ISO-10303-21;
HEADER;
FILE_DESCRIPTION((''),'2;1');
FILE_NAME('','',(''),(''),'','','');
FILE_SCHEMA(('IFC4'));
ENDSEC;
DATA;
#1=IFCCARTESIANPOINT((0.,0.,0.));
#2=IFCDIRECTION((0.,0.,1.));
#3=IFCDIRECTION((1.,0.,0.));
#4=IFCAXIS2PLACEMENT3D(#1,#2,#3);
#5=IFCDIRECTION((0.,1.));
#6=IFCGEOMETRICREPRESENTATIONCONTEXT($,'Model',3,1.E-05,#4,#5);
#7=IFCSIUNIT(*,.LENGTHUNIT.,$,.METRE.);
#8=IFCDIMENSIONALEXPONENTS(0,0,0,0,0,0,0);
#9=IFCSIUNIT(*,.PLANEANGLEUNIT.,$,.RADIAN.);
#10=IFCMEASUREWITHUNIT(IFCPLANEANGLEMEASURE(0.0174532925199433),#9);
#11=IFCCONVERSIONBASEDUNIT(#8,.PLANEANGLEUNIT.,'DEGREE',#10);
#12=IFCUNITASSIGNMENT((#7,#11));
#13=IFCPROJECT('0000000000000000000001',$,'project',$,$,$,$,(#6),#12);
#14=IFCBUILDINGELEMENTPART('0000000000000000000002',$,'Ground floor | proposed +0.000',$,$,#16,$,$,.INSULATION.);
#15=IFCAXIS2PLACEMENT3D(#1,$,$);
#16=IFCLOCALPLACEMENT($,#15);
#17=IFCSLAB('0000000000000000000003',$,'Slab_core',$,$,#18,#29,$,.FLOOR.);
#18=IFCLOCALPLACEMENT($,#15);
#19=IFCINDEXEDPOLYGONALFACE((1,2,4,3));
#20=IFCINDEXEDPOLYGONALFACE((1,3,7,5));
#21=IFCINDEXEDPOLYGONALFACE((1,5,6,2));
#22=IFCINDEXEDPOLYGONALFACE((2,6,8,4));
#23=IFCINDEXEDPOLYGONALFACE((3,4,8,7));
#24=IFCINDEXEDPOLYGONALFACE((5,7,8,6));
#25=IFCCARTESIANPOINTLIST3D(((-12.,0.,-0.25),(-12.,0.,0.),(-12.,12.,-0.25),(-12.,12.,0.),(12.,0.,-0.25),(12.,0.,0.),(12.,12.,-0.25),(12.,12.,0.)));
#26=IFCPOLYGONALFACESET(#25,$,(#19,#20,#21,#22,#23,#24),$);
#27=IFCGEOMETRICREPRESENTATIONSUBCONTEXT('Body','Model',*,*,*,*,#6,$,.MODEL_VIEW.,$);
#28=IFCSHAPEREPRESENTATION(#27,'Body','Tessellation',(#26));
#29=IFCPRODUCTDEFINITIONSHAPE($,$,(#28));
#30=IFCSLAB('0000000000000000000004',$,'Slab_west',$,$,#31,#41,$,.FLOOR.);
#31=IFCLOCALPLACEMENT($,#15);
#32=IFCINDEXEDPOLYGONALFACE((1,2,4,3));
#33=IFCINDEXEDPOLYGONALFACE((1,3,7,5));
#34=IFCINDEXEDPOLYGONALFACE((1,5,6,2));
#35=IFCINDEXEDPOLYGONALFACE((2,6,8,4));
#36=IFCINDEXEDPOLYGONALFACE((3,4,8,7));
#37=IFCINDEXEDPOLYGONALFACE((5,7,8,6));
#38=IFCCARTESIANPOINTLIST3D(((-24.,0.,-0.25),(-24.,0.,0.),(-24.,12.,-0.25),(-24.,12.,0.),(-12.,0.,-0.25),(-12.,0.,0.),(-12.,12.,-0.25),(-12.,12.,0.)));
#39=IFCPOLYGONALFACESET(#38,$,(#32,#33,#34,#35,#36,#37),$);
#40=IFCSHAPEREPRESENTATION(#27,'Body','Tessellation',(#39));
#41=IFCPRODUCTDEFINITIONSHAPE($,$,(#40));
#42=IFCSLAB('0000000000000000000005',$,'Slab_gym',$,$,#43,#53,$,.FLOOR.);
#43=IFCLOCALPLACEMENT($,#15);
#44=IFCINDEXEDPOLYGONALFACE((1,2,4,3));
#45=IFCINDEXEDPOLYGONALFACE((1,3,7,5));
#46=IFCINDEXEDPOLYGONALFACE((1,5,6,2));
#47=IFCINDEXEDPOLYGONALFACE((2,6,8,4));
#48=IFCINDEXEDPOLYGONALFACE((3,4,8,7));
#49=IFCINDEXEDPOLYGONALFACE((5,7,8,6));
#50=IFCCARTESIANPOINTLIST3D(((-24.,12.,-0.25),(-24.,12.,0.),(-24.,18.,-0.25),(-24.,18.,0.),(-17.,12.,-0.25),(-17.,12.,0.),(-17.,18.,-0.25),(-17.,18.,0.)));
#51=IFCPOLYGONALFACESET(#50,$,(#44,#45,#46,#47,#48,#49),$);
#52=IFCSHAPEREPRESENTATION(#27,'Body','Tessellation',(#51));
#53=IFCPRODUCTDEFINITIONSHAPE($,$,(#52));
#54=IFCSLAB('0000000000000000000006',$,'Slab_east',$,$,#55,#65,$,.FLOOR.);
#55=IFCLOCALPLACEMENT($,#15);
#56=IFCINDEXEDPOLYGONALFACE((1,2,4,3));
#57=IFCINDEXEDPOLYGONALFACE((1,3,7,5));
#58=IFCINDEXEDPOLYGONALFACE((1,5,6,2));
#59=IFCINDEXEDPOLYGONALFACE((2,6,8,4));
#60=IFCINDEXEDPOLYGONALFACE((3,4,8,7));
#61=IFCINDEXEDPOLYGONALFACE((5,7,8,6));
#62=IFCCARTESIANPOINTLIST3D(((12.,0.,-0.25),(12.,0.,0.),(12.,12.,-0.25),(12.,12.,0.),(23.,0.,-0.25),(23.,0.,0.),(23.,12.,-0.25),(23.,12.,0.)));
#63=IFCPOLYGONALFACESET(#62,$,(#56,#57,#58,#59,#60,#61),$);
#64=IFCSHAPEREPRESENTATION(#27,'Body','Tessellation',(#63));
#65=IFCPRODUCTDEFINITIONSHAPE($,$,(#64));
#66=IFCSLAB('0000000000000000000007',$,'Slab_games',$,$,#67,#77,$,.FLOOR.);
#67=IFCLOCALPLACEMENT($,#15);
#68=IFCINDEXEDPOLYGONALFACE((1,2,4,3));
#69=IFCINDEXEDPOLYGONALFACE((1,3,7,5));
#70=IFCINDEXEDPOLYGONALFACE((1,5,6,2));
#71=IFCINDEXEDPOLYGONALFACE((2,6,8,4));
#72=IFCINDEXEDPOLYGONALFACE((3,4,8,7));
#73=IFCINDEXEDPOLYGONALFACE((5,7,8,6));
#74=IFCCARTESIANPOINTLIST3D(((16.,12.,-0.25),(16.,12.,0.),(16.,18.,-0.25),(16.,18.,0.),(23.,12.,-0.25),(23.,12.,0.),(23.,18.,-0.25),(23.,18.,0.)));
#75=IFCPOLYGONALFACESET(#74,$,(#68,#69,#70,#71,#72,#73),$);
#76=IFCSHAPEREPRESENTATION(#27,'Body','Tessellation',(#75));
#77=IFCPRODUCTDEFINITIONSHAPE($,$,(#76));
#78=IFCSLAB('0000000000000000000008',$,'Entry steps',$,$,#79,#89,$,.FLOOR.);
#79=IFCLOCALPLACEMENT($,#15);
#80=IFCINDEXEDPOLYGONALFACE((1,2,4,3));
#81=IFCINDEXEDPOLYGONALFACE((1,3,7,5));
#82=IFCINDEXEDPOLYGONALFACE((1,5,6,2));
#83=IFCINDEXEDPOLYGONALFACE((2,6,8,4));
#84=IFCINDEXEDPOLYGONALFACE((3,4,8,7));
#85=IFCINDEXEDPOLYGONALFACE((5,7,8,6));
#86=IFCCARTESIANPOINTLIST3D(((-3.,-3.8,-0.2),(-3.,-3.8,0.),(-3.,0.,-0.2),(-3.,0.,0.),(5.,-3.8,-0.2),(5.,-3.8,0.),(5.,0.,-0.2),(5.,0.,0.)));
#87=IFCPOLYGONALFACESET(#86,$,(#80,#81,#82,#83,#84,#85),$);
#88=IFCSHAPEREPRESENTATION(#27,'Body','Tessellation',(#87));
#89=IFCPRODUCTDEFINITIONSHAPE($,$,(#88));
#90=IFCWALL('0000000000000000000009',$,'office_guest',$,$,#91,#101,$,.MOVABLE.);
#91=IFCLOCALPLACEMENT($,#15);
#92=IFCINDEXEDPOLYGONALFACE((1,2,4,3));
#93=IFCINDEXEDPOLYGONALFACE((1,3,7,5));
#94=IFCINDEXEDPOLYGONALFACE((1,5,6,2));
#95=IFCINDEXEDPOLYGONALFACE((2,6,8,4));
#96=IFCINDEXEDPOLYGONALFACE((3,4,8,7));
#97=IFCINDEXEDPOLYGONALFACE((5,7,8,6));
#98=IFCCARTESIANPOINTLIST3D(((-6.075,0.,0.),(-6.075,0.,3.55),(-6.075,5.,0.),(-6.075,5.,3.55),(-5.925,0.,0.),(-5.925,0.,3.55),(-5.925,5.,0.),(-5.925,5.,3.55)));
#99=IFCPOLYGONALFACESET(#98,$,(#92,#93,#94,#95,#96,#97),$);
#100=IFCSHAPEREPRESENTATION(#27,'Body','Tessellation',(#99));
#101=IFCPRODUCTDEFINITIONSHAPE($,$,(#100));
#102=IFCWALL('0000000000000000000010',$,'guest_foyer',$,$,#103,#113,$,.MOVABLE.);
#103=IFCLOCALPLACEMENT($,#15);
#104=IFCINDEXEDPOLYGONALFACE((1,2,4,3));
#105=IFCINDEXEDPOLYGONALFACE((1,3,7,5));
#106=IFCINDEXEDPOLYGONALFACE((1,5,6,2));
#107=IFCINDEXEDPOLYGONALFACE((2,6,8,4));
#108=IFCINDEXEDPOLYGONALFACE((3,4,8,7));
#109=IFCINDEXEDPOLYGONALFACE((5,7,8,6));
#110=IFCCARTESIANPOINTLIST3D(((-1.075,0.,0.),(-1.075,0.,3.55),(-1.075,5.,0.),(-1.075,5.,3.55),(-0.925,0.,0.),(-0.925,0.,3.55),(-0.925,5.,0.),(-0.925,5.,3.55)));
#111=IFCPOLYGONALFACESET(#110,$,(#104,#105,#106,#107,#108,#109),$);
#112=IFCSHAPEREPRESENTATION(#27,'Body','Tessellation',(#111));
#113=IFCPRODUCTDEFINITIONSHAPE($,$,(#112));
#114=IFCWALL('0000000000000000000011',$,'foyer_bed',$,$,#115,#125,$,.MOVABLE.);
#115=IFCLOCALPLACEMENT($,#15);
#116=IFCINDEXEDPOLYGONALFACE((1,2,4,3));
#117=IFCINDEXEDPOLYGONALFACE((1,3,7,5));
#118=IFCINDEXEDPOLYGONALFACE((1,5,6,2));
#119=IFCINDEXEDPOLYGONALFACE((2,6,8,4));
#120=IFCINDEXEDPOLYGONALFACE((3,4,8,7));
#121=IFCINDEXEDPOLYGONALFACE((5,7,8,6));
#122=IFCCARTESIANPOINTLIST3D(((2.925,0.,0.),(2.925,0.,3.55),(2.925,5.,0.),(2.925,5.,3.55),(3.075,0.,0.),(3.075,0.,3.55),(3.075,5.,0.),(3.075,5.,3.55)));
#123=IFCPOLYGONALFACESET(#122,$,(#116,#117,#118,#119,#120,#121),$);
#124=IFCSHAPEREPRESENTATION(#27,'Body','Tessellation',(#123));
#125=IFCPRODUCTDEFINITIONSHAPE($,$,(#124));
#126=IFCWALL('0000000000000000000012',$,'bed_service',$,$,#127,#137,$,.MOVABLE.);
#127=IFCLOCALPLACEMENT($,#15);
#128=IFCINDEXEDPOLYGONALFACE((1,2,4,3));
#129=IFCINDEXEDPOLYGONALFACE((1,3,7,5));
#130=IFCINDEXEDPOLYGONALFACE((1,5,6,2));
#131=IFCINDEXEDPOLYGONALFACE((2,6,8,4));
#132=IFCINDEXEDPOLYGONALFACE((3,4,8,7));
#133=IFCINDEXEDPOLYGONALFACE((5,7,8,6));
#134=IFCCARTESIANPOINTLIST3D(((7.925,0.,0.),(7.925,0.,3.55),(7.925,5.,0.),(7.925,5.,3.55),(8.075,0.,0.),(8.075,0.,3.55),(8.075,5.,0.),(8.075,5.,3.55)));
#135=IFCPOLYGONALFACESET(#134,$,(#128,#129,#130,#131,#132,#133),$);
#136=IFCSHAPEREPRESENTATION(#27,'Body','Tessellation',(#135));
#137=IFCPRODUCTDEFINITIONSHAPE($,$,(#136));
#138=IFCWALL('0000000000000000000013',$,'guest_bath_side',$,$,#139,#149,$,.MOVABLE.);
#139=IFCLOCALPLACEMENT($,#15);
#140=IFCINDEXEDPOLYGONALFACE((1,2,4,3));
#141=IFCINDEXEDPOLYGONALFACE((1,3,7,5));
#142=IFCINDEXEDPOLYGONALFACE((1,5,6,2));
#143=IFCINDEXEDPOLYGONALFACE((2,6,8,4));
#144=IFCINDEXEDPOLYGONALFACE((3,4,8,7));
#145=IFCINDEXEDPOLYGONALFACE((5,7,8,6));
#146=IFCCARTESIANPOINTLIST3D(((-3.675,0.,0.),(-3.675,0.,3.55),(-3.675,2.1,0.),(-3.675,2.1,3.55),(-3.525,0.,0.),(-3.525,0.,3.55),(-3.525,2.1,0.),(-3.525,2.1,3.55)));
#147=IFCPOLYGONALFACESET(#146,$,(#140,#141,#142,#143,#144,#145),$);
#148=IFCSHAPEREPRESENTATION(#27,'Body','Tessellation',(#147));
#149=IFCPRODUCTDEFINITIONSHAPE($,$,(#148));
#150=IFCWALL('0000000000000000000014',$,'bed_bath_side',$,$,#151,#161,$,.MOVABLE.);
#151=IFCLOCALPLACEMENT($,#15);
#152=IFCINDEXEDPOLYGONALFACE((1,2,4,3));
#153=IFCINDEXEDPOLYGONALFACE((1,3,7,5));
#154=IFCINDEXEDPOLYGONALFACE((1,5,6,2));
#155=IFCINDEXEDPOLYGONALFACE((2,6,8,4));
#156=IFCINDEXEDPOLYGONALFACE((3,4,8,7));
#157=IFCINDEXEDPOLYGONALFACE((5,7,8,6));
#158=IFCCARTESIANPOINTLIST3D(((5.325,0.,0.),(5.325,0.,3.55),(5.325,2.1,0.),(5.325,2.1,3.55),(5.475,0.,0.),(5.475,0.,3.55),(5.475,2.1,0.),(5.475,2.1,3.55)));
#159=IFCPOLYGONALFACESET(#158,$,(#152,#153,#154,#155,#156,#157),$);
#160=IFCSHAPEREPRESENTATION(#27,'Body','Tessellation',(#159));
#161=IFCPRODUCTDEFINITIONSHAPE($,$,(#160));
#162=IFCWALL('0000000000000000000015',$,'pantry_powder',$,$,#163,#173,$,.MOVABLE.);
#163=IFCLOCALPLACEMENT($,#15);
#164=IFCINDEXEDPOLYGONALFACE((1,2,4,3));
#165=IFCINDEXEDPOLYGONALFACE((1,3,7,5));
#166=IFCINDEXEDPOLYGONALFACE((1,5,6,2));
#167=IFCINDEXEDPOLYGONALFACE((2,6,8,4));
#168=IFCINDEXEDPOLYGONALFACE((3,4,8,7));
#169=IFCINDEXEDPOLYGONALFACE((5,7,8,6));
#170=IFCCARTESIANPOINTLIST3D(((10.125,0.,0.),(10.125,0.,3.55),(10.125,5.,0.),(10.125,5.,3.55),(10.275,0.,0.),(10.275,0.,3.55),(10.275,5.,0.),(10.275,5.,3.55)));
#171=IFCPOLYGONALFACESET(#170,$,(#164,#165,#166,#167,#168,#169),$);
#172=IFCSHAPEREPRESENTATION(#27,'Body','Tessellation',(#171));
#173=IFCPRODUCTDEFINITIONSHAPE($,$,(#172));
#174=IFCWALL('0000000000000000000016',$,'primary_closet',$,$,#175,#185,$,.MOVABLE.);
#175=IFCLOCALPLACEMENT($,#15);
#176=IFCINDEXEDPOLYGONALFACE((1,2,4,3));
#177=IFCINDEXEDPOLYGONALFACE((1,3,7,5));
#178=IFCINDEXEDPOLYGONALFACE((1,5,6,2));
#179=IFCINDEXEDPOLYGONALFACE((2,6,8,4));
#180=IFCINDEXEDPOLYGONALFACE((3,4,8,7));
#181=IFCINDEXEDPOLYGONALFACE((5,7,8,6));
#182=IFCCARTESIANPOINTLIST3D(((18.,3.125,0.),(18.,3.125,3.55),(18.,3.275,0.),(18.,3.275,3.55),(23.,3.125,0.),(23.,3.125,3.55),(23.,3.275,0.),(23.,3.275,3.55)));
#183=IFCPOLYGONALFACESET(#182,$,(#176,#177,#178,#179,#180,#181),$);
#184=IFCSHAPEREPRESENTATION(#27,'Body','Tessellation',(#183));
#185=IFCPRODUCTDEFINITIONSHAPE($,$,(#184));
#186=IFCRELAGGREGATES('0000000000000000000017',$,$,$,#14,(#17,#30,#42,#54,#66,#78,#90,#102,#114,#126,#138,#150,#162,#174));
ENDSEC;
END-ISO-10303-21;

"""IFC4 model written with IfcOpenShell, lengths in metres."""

from ifc_helpers import new_model, entity, si_unit, converted_unit, direction, frame, frame_2d, origin_with_axes, origin_2d_with_axis, place, context, subcontext, project, rectangle, extrude, element, aggregate, save


model = new_model("IFC4")

# Units and contexts
model_context = context("Model", 3, precision=1e-05, world=origin_with_axes(), true_north=direction((0.0, 1.0)))
body_context = subcontext(model_context, "Body", "Model", "MODEL_VIEW")
ifc_project = project(units=[si_unit("LENGTHUNIT", "METRE"), converted_unit("PLANEANGLEUNIT", "DEGREE", entity("IfcPlaneAngleMeasure", 0.0174532925199433), si_unit("PLANEANGLEUNIT", "RADIAN"), dimensions=[0, 0, 0, 0, 0, 0, 0])], contexts=[model_context])

# Building element part, slabs, walls
building_element_part = element("IfcBuildingElementPart", 1, Name="Ground floor | proposed +0.000", PredefinedType="INSULATION")
placement = place(None, origin_with_axes())
slab_1 = element("IfcSlab", 2, at=placement, Name="Slab_core", PredefinedType="FLOOR", context=body_context, shape_type="SweptSolid", body=[
    extrude(rectangle(XDim=24.0, YDim=12.0, at=frame_2d((0.0, 0.0), x_axis=(1.0, 0.0))), frame((0.0, 6.0, -0.25), z_axis=(0.0, 0.0, 1.0), x_axis=(1.0, 0.0, 0.0)), (0.0, 0.0, 1.0), 0.25),
])
slab_2 = element("IfcSlab", 3, at=placement, Name="Slab_west", PredefinedType="FLOOR", context=body_context, shape_type="SweptSolid", body=[
    extrude(rectangle(XDim=12.0, YDim=12.0, at=origin_2d_with_axis()), frame((-18.0, 6.0, -0.25), z_axis=(0.0, 0.0, 1.0), x_axis=(1.0, 0.0, 0.0)), (0.0, 0.0, 1.0), 0.25),
])
slab_3 = element("IfcSlab", 4, at=placement, Name="Slab_gym", PredefinedType="FLOOR", context=body_context, shape_type="SweptSolid", body=[
    extrude(rectangle(XDim=7.0, YDim=6.0, at=origin_2d_with_axis()), frame((-20.5, 15.0, -0.25), z_axis=(0.0, 0.0, 1.0), x_axis=(1.0, 0.0, 0.0)), (0.0, 0.0, 1.0), 0.25),
])
slab_4 = element("IfcSlab", 5, at=placement, Name="Slab_east", PredefinedType="FLOOR", context=body_context, shape_type="SweptSolid", body=[
    extrude(rectangle(XDim=11.0, YDim=12.0, at=origin_2d_with_axis()), frame((17.5, 6.0, -0.25), z_axis=(0.0, 0.0, 1.0), x_axis=(1.0, 0.0, 0.0)), (0.0, 0.0, 1.0), 0.25),
])
slab_5 = element("IfcSlab", 6, at=placement, Name="Slab_games", PredefinedType="FLOOR", context=body_context, shape_type="SweptSolid", body=[
    extrude(rectangle(XDim=7.0, YDim=6.0, at=origin_2d_with_axis()), frame((19.5, 15.0, -0.25), z_axis=(0.0, 0.0, 1.0), x_axis=(1.0, 0.0, 0.0)), (0.0, 0.0, 1.0), 0.25),
])
slab_6 = element("IfcSlab", 7, at=placement, Name="Entry steps", PredefinedType="FLOOR", context=body_context, shape_type="SweptSolid", body=[
    extrude(rectangle(XDim=8.0, YDim=3.8, at=origin_2d_with_axis()), frame((1.0, -1.9, -0.2), z_axis=(0.0, 0.0, 1.0), x_axis=(1.0, 0.0, 0.0)), (0.0, 0.0, 1.0), 0.2),
])
wall_1 = element("IfcWall", 8, at=placement, Name="office_guest", PredefinedType="MOVABLE", context=body_context, shape_type="SweptSolid", body=[
    extrude(rectangle(XDim=5.0, YDim=0.15, at=frame_2d((0.0, 0.0), x_axis=(0.0, 1.0))), frame((-6.0, 2.5, 0.0), z_axis=(0.0, 0.0, 1.0), x_axis=(1.0, 0.0, 0.0)), (0.0, 0.0, 1.0), 3.55),
])
wall_2 = element("IfcWall", 9, at=placement, Name="guest_foyer", PredefinedType="MOVABLE", context=body_context, shape_type="SweptSolid", body=[
    extrude(rectangle(XDim=5.0, YDim=0.15, at=frame_2d((0.0, 0.0), x_axis=(0.0, 1.0))), frame((-1.0, 2.5, 0.0), z_axis=(0.0, 0.0, 1.0), x_axis=(1.0, 0.0, 0.0)), (0.0, 0.0, 1.0), 3.55),
])
wall_3 = element("IfcWall", 10, at=placement, Name="foyer_bed", PredefinedType="MOVABLE", context=body_context, shape_type="SweptSolid", body=[
    extrude(rectangle(XDim=5.0, YDim=0.15, at=frame_2d((0.0, 0.0), x_axis=(0.0, 1.0))), frame((3.0, 2.5, 0.0), z_axis=(0.0, 0.0, 1.0), x_axis=(1.0, 0.0, 0.0)), (0.0, 0.0, 1.0), 3.55),
])
wall_4 = element("IfcWall", 11, at=placement, Name="bed_service", PredefinedType="MOVABLE", context=body_context, shape_type="SweptSolid", body=[
    extrude(rectangle(XDim=5.0, YDim=0.15, at=frame_2d((0.0, 0.0), x_axis=(0.0, 1.0))), frame((8.0, 2.5, 0.0), z_axis=(0.0, 0.0, 1.0), x_axis=(1.0, 0.0, 0.0)), (0.0, 0.0, 1.0), 3.55),
])
wall_5 = element("IfcWall", 12, at=placement, Name="guest_bath_side", PredefinedType="MOVABLE", context=body_context, shape_type="SweptSolid", body=[
    extrude(rectangle(XDim=2.1, YDim=0.15, at=frame_2d((0.0, 0.0), x_axis=(0.0, 1.0))), frame((-3.6, 1.05, 0.0), z_axis=(0.0, 0.0, 1.0), x_axis=(1.0, 0.0, 0.0)), (0.0, 0.0, 1.0), 3.55),
])
wall_6 = element("IfcWall", 13, at=placement, Name="bed_bath_side", PredefinedType="MOVABLE", context=body_context, shape_type="SweptSolid", body=[
    extrude(rectangle(XDim=2.1, YDim=0.15, at=frame_2d((0.0, 0.0), x_axis=(0.0, 1.0))), frame((5.4, 1.05, 0.0), z_axis=(0.0, 0.0, 1.0), x_axis=(1.0, 0.0, 0.0)), (0.0, 0.0, 1.0), 3.55),
])
wall_7 = element("IfcWall", 14, at=placement, Name="pantry_powder", PredefinedType="MOVABLE", context=body_context, shape_type="SweptSolid", body=[
    extrude(rectangle(XDim=5.0, YDim=0.15, at=frame_2d((0.0, 0.0), x_axis=(0.0, 1.0))), frame((10.2, 2.5, 0.0), z_axis=(0.0, 0.0, 1.0), x_axis=(1.0, 0.0, 0.0)), (0.0, 0.0, 1.0), 3.55),
])
wall_8 = element("IfcWall", 15, at=placement, Name="primary_closet", PredefinedType="MOVABLE", context=body_context, shape_type="SweptSolid", body=[
    extrude(rectangle(XDim=5.0, YDim=0.15, at=frame_2d((0.0, 0.0), x_axis=(1.0, 0.0))), frame((20.5, 3.2, 0.0), z_axis=(0.0, 0.0, 1.0), x_axis=(1.0, 0.0, 0.0)), (0.0, 0.0, 1.0), 3.55),
])
aggregate(building_element_part, [slab_1, slab_2, slab_3, slab_4, slab_5, slab_6, wall_1, wall_2, wall_3, wall_4, wall_5, wall_6, wall_7, wall_8])

save(model, "model.ifc")
